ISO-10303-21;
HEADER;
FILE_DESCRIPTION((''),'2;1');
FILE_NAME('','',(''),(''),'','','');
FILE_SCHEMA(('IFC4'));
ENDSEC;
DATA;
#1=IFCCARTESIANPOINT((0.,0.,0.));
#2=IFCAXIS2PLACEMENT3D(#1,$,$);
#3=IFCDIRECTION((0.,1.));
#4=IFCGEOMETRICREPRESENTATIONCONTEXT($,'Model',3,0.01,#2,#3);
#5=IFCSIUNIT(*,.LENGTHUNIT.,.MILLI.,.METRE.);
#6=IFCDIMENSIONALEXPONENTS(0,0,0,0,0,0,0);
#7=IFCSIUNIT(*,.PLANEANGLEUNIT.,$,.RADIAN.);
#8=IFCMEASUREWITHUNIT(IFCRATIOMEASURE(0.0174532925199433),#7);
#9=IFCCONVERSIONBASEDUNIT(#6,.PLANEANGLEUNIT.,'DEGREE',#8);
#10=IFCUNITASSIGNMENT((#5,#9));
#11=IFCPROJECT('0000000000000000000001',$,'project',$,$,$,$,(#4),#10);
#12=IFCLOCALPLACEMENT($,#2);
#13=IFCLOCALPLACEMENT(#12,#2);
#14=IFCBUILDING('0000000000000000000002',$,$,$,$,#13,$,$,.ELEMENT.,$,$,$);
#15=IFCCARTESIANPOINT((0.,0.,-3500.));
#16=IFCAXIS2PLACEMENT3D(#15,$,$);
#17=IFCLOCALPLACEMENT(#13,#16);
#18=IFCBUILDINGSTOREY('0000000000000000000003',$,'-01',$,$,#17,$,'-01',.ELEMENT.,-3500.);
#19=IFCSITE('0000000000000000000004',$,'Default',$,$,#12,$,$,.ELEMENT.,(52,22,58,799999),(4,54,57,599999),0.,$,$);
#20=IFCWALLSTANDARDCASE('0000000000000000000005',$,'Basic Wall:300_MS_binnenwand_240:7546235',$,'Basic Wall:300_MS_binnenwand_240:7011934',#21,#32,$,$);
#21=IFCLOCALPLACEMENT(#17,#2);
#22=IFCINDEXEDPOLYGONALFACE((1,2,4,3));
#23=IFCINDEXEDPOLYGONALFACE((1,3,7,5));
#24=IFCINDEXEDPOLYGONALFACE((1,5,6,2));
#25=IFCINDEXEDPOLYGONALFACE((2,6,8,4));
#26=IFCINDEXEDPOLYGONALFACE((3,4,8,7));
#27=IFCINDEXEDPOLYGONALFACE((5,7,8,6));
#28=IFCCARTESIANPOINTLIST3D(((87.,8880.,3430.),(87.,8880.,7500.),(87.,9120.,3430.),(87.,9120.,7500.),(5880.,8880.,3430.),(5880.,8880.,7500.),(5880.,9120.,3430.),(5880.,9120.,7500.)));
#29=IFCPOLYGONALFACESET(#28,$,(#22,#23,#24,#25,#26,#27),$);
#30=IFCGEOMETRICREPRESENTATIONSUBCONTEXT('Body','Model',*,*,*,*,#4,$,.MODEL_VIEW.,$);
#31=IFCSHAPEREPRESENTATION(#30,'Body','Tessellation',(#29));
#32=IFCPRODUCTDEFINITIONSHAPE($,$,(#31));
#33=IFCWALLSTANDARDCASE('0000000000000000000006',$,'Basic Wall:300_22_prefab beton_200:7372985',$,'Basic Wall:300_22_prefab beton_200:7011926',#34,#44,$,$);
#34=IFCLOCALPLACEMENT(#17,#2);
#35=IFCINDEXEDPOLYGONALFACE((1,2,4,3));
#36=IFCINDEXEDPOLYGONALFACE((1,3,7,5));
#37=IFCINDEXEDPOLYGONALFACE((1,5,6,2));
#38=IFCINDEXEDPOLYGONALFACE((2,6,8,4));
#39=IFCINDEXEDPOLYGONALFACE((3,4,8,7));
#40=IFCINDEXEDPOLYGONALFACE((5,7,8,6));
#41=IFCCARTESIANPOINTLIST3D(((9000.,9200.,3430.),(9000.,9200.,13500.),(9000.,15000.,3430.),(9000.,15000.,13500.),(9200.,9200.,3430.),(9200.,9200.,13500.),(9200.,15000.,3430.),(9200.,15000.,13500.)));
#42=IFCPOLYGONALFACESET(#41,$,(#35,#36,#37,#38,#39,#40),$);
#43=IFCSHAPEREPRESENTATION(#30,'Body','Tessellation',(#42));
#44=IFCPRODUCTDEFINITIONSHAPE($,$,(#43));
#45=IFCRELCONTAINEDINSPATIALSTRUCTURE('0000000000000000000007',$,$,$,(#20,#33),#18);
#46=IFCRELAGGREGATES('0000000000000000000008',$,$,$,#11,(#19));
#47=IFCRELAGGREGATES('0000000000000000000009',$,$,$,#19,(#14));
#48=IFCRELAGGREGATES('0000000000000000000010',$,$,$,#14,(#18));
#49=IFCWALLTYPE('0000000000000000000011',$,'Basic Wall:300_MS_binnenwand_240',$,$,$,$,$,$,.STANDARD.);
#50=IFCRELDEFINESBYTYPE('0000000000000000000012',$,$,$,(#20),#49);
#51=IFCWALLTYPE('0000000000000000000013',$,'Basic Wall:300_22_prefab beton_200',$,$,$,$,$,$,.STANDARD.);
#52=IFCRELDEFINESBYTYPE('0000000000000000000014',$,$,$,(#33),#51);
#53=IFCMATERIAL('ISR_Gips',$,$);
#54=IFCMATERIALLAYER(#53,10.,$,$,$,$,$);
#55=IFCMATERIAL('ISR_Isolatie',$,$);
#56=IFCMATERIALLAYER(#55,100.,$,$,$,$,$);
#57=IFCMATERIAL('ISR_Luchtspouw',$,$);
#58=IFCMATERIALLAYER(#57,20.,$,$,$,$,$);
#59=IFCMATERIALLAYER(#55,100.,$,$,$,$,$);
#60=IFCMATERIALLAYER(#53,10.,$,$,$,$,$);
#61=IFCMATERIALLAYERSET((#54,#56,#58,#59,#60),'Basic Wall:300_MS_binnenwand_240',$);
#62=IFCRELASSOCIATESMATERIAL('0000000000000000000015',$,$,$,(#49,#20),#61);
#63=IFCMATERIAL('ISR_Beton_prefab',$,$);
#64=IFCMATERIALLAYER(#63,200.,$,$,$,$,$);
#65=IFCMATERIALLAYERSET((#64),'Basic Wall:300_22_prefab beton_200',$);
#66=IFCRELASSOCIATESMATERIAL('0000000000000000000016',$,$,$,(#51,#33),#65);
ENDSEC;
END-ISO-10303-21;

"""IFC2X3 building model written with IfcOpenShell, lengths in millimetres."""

from ifc_helpers import new_model, entity, si_unit, converted_unit, direction, frame, frame_2d, origin, place, context, subcontext, project, spatial, rectangle, extrude, material, layer, layer_set, layer_usage, type_object, element, save


model = new_model("IFC2X3")

# Units and contexts
model_context = context("Model", 3, precision=0.01, world=origin(), true_north=direction((0.0, 1.0)))
body_context = subcontext(model_context, "Body", "Model", "MODEL_VIEW")
ifc_project = project(units=[si_unit("LENGTHUNIT", "METRE", prefix="MILLI"), converted_unit("PLANEANGLEUNIT", "DEGREE", entity("IfcRatioMeasure", 0.0174532925199433), si_unit("PLANEANGLEUNIT", "RADIAN"), dimensions=[0, 0, 0, 0, 0, 0, 0])], contexts=[model_context])

# Site, building, storey
site_placement = place(None, origin())
site = spatial("IfcSite", under=ifc_project, at=site_placement, Name="Default", CompositionType="ELEMENT", RefLatitude=(52, 22, 58, 799999), RefLongitude=(4, 54, 57, 599999), RefElevation=0.0)
building_placement = place(site_placement, origin())
building = spatial("IfcBuilding", under=site, at=building_placement, CompositionType="ELEMENT")
storey_placement = place(building_placement, frame((0.0, 0.0, -3500.0)))
storey = spatial("IfcBuildingStorey", under=building, at=storey_placement, Name="-01", LongName="-01", CompositionType="ELEMENT", Elevation=-3500.0)

# Shared definitions
ifc_material_1 = material(Name="ISR_Gips")
ifc_layer_1 = layer(ifc_material_1, 10.0)
ifc_material_2 = material(Name="ISR_Isolatie")
ifc_layer_2 = layer(ifc_material_2, 100.0)
ifc_material_3 = material(Name="ISR_Luchtspouw")
ifc_layer_3 = layer(ifc_material_3, 20.0)
ifc_layer_4 = layer(ifc_material_2, 100.0)
ifc_layer_5 = layer(ifc_material_1, 10.0)
ifc_layer_set_1 = layer_set([ifc_layer_1, ifc_layer_2, ifc_layer_3, ifc_layer_4, ifc_layer_5], Name="Basic Wall:300_MS_binnenwand_240")
wall_type_1 = type_object("IfcWallType", Name="Basic Wall:300_MS_binnenwand_240", PredefinedType="STANDARD", material=ifc_layer_set_1)

# Walls
ifc_layer_usage_1 = layer_usage(ifc_layer_set_1, "AXIS2", "NEGATIVE", 120.0)
wall_1_placement = place(storey_placement, frame((87.0, 9000.0, 3430.0)))
element("IfcWallStandardCase", 1, at=wall_1_placement, inside=storey, type_object=wall_type_1, material=ifc_layer_usage_1, Name="Basic Wall:300_MS_binnenwand_240:7546235", ObjectType="Basic Wall:300_MS_binnenwand_240:7011934", context=body_context, shape_type="SweptSolid", body=[
    extrude(rectangle(XDim=5793.0, YDim=240.0, at=frame_2d((2896.5, 0.0), x_axis=(-1.0, 0.0))), origin(), (0.0, 0.0, 1.0), 4070.0),
])
ifc_material_4 = material(Name="ISR_Beton_prefab")
ifc_layer_6 = layer(ifc_material_4, 200.0)
ifc_layer_set_2 = layer_set([ifc_layer_6], Name="Basic Wall:300_22_prefab beton_200")
ifc_layer_usage_2 = layer_usage(ifc_layer_set_2, "AXIS2", "NEGATIVE", 100.0)
wall_type_2 = type_object("IfcWallType", Name="Basic Wall:300_22_prefab beton_200", PredefinedType="STANDARD", material=ifc_layer_set_2)
wall_2_placement = place(storey_placement, frame((9100.0, 9200.0, 3430.0), z_axis=(0.0, 0.0, 1.0), x_axis=(0.0, 1.0, 0.0)))
element("IfcWallStandardCase", 2, at=wall_2_placement, inside=storey, type_object=wall_type_2, material=ifc_layer_usage_2, Name="Basic Wall:300_22_prefab beton_200:7372985", ObjectType="Basic Wall:300_22_prefab beton_200:7011926", context=body_context, shape_type="SweptSolid", body=[
    extrude(rectangle(XDim=5800.0, YDim=200.0, at=frame_2d((2900.0, 0.0), x_axis=(-1.0, 0.0))), origin(), (0.0, 0.0, 1.0), 10070.0),
])

save(model, "model.ifc")
